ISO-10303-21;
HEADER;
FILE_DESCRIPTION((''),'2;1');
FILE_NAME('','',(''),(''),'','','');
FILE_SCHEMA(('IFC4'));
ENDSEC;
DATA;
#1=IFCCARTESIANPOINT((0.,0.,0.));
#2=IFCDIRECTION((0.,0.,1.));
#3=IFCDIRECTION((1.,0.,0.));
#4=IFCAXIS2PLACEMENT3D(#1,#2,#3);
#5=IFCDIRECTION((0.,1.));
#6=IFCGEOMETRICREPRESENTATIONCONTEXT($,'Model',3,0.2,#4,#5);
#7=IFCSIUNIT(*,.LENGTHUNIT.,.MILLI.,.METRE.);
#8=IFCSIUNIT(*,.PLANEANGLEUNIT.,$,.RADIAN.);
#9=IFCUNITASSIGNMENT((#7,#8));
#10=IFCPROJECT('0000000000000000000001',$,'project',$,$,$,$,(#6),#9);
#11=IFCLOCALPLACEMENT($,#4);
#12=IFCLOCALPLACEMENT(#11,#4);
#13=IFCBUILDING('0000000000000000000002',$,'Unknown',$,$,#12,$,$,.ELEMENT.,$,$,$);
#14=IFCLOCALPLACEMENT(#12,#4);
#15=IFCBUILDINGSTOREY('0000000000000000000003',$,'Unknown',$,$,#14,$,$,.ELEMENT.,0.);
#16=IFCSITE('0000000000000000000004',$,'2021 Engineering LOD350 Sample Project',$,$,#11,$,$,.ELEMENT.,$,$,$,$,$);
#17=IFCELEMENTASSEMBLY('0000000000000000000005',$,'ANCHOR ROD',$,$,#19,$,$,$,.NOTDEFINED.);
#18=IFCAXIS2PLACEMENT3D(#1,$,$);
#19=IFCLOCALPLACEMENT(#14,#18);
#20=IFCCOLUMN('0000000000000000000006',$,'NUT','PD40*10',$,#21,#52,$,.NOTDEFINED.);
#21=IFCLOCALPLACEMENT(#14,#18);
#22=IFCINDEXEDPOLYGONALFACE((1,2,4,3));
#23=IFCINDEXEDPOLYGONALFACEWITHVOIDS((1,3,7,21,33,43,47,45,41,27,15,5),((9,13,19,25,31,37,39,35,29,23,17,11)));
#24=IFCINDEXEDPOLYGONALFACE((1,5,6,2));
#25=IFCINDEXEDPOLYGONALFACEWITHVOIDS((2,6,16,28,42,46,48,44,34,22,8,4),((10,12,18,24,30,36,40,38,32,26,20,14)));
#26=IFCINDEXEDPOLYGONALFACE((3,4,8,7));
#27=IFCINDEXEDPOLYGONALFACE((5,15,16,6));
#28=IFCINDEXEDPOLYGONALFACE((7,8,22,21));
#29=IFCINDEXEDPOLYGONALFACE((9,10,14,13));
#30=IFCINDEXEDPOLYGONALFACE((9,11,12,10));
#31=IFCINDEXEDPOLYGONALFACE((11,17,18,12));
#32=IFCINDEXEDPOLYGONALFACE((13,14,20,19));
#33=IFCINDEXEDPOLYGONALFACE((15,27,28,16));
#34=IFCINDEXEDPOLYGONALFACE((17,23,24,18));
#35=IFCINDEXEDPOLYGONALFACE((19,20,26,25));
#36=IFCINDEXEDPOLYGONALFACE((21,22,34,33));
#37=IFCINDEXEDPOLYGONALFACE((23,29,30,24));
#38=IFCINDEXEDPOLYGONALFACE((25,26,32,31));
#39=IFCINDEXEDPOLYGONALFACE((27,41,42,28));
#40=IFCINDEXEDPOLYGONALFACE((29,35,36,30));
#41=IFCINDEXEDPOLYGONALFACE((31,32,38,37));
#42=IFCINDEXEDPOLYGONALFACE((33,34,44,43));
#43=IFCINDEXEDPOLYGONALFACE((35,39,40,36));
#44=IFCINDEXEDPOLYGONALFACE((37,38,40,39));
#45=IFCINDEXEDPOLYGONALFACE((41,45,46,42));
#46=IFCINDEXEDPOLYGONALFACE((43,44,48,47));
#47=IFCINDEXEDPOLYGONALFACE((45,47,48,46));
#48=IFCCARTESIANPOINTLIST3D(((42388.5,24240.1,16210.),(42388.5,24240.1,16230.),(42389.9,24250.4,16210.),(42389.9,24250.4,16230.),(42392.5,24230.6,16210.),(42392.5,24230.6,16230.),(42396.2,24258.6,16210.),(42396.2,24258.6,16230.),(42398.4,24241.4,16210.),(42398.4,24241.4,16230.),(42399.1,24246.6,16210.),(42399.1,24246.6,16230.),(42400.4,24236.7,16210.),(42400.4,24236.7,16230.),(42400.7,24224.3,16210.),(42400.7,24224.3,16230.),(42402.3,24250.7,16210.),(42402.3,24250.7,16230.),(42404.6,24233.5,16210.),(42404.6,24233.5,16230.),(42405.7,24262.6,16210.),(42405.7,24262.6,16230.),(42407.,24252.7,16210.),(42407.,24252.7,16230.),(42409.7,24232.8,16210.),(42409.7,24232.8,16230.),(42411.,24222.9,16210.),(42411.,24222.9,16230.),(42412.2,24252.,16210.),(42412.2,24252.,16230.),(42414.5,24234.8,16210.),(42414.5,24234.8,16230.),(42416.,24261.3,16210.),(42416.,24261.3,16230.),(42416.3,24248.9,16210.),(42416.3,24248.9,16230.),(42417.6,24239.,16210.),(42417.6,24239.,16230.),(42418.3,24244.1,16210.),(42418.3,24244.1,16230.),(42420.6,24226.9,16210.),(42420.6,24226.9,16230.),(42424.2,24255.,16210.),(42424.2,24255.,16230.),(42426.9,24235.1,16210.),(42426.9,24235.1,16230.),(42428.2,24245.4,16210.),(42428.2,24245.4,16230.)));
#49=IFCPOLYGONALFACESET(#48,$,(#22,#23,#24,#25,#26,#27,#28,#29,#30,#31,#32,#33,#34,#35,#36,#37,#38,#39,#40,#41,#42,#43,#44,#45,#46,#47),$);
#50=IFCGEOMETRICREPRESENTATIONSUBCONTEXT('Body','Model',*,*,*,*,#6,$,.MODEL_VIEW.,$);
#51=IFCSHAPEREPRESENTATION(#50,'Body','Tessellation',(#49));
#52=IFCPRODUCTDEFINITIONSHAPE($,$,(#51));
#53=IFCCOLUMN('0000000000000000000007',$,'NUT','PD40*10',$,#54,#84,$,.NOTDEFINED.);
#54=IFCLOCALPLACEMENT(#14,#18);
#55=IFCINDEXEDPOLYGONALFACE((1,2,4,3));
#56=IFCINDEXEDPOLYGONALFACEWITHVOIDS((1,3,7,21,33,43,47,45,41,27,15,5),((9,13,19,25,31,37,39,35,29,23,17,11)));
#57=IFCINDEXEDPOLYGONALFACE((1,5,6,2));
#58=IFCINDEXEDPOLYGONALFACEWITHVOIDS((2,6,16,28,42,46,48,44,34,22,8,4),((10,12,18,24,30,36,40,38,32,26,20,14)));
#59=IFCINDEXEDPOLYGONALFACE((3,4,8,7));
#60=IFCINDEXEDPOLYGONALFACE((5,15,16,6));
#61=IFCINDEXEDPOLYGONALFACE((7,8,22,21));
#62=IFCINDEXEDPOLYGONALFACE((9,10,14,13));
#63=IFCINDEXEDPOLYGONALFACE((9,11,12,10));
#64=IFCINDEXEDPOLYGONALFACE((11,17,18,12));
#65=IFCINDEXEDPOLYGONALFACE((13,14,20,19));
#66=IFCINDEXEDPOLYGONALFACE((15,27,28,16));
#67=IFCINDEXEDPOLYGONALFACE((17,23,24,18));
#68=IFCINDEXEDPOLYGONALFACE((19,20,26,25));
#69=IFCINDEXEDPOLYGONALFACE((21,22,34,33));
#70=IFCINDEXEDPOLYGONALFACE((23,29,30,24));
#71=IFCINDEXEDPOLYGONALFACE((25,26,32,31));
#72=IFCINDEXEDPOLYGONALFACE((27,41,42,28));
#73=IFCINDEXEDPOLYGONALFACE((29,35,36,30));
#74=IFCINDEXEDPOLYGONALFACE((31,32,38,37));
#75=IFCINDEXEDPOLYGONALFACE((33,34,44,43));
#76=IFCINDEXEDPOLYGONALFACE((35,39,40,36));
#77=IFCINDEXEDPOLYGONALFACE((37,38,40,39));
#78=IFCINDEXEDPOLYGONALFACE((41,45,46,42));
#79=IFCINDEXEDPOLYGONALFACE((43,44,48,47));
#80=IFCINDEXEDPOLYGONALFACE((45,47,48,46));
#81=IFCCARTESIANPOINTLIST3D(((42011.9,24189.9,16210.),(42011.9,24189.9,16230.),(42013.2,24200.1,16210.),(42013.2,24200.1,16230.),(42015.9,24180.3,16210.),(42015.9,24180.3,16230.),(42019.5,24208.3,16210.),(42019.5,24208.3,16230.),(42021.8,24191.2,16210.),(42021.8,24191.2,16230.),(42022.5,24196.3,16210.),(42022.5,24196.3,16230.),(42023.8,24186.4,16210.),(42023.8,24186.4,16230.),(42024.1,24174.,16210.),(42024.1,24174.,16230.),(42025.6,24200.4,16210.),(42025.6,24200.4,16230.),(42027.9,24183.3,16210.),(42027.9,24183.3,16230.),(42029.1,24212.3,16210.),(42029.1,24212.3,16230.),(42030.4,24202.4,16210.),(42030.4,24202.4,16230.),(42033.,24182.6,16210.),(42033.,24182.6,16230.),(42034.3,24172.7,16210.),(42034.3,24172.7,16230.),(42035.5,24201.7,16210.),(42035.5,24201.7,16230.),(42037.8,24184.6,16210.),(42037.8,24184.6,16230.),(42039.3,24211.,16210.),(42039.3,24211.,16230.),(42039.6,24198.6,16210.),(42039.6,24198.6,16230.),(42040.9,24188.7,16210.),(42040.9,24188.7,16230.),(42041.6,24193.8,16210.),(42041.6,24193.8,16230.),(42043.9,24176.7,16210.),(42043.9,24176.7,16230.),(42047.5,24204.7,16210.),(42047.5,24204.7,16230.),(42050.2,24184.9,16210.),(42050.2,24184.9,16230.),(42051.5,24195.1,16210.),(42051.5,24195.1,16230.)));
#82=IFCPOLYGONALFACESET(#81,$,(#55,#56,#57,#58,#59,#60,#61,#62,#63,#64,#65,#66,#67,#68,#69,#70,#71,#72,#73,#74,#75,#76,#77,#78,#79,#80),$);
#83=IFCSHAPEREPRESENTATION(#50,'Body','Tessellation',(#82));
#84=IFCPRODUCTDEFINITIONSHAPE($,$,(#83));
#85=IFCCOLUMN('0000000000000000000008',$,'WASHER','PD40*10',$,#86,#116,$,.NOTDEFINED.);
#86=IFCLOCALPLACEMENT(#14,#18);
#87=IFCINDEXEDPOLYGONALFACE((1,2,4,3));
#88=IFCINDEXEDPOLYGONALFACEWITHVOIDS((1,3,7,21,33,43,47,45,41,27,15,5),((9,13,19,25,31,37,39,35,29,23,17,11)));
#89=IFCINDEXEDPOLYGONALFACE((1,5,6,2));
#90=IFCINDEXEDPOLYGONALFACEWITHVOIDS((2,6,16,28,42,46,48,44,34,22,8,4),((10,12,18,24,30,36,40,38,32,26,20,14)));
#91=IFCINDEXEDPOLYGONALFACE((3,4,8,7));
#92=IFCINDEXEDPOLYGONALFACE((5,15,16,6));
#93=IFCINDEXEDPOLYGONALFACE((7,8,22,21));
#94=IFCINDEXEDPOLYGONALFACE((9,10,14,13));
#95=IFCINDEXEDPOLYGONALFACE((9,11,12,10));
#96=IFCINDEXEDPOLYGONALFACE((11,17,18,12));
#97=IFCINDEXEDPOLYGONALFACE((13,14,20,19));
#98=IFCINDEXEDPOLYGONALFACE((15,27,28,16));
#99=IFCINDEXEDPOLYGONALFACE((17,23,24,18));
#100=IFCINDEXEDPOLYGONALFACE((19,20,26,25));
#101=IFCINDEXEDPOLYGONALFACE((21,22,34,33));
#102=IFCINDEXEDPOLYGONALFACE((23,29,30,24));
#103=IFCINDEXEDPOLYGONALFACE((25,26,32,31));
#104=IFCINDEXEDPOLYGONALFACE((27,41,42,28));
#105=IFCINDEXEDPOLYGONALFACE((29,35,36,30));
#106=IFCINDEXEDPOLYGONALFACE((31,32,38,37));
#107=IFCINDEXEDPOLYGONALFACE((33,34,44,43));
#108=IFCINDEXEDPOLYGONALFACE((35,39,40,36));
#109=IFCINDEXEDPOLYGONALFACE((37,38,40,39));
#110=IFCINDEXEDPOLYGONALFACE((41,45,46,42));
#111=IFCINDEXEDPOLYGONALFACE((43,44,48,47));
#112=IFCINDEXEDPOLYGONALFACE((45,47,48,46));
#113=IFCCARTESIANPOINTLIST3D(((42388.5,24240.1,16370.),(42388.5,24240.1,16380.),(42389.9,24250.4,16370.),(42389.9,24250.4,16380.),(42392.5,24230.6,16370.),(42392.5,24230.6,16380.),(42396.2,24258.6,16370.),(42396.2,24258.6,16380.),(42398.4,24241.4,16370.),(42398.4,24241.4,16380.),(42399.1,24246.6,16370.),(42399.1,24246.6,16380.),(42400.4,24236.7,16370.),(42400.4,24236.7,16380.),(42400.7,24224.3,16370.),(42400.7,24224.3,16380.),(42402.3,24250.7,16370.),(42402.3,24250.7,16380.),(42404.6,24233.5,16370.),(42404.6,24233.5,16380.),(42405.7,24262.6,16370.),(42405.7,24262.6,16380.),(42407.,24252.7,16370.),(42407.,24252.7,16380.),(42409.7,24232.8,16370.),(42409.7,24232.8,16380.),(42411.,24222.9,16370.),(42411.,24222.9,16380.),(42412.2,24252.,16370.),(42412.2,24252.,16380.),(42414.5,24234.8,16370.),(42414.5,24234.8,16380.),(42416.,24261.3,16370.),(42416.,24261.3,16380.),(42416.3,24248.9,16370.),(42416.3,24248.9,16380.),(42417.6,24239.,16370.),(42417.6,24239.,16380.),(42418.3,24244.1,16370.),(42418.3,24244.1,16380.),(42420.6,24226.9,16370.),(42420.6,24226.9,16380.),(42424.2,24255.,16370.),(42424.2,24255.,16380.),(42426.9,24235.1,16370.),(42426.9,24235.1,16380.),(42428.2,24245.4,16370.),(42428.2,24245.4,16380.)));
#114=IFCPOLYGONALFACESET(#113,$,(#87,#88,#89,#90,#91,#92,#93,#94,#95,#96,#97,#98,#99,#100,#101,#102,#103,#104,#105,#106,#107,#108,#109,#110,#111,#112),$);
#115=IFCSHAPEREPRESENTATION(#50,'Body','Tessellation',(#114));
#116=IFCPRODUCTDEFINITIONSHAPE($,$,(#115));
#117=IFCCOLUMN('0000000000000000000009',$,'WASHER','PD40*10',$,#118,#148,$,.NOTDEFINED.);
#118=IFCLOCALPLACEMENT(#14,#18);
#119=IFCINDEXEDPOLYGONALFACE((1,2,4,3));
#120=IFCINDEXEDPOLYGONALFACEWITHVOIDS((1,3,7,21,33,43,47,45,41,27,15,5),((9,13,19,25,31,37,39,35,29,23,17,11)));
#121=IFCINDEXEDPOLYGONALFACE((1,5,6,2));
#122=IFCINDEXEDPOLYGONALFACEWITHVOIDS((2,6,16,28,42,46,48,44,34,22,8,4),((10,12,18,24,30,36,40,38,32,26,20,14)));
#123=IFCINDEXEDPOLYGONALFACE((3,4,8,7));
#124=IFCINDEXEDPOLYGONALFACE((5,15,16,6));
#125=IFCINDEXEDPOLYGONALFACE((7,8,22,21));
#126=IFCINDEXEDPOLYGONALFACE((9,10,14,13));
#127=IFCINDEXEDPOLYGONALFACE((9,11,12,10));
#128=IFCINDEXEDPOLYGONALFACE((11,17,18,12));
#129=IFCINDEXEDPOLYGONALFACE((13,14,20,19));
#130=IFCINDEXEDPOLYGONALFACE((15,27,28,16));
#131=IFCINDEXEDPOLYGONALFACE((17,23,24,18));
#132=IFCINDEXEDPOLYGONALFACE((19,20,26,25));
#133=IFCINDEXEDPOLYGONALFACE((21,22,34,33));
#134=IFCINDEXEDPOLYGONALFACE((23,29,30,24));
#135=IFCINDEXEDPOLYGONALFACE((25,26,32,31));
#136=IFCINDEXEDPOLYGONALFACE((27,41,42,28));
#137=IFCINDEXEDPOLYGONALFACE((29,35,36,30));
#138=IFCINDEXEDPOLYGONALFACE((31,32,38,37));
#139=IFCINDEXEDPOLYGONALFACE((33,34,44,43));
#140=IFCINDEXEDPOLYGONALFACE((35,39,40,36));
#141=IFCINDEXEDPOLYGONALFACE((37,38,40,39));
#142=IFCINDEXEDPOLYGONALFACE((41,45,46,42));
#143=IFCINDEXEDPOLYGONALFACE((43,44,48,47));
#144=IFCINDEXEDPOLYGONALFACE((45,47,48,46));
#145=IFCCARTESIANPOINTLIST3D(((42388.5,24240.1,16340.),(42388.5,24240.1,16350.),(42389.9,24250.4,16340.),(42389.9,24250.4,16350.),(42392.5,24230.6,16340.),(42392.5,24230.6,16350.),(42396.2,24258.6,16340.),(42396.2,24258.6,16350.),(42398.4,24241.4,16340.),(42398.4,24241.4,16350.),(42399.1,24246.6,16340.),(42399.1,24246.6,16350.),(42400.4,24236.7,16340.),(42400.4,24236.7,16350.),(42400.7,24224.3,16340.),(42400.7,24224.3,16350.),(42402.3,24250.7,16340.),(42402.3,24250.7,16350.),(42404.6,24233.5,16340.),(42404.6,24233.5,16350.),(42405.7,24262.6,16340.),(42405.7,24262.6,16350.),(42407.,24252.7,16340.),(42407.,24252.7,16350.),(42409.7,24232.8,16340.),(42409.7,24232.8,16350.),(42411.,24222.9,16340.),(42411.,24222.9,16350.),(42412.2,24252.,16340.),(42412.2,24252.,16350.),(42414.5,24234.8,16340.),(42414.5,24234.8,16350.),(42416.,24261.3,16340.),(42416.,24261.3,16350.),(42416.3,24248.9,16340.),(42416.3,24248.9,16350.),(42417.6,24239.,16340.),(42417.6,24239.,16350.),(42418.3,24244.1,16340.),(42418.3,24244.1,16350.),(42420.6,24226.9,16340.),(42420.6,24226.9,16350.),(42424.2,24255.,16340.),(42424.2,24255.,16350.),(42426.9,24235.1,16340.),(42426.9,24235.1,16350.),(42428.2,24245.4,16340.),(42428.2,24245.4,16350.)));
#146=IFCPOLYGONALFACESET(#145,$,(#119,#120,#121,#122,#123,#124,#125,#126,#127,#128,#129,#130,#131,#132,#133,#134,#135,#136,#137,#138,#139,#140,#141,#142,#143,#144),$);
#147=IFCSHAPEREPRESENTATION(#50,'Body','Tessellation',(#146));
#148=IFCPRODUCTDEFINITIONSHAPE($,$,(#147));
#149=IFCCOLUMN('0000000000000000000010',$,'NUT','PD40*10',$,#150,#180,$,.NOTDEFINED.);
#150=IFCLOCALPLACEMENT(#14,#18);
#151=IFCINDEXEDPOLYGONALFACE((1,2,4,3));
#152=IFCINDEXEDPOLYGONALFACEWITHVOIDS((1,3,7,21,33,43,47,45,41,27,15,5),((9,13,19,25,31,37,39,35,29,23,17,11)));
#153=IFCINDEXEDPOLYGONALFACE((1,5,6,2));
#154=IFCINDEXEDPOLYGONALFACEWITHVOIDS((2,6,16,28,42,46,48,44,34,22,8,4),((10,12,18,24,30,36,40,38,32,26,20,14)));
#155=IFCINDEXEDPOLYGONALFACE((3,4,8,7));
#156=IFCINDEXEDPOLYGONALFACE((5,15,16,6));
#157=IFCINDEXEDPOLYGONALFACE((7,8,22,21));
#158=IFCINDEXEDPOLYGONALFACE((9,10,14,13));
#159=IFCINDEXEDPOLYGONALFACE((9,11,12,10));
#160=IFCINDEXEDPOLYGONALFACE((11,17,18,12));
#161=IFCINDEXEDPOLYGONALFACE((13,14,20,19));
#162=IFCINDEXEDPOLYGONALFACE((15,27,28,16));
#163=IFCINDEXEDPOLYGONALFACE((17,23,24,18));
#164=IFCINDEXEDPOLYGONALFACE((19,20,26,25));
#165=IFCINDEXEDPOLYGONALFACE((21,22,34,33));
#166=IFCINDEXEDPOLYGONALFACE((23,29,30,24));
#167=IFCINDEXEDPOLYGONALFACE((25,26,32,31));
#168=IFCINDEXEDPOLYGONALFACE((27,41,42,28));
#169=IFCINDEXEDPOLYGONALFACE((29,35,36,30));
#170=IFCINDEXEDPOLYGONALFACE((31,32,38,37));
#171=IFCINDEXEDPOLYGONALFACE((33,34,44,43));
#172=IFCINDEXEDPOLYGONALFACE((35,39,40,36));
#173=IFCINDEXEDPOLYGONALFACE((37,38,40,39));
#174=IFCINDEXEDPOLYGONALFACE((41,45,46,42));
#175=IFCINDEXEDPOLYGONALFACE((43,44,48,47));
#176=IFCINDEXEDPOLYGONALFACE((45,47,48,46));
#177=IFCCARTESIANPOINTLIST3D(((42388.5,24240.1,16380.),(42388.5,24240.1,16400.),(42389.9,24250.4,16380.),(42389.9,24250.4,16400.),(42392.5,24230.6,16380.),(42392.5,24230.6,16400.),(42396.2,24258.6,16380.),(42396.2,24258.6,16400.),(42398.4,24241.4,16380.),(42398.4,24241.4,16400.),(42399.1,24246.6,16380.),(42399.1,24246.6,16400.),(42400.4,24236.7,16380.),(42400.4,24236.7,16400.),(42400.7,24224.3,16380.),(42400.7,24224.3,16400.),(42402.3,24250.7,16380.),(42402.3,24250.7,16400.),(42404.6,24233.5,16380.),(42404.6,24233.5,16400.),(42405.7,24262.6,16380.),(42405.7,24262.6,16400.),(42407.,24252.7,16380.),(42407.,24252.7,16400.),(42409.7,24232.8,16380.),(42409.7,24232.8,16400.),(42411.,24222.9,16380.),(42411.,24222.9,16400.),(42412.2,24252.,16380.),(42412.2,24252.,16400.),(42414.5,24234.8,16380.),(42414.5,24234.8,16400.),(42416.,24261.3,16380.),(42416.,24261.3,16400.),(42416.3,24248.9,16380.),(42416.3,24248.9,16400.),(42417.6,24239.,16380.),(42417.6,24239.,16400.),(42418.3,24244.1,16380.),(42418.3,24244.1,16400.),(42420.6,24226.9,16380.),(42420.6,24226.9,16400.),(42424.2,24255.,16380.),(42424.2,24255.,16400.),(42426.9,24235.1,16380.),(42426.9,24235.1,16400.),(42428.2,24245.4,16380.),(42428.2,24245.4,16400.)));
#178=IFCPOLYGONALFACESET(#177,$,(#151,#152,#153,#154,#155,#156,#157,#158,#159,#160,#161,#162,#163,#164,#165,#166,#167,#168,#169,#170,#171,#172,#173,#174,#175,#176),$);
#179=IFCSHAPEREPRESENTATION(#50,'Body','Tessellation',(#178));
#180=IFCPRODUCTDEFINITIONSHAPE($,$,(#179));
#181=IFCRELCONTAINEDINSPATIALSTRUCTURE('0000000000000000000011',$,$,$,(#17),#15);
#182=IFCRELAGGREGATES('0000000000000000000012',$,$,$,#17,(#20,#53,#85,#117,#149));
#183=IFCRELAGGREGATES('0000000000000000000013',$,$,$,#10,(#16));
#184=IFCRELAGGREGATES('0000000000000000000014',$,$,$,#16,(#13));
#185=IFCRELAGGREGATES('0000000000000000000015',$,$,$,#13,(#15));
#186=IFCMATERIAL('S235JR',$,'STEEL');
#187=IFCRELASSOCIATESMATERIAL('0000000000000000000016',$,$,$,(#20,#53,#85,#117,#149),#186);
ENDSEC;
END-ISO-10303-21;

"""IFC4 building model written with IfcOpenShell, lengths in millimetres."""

from ifc_helpers import new_model, si_unit, direction, frame, origin_with_axes, place, context, subcontext, project, spatial, line, indexed_curve, outline, extrude, material, element, aggregate, save


model = new_model("IFC4")

# Units and contexts
model_context = context("Model", 3, precision=0.2, world=origin_with_axes(), true_north=direction((0.0, 1.0)))
body_context = subcontext(model_context, "Body", "Model", "MODEL_VIEW")
ifc_project = project(units=[si_unit("LENGTHUNIT", "METRE", prefix="MILLI"), si_unit("PLANEANGLEUNIT", "RADIAN")], contexts=[model_context])

# Site, building, storey
site_placement = place(None, origin_with_axes())
site = spatial("IfcSite", under=ifc_project, at=site_placement, Name="2021 Engineering LOD350 Sample Project", CompositionType="ELEMENT")
building_placement = place(site_placement, origin_with_axes())
building = spatial("IfcBuilding", under=site, at=building_placement, Name="Unknown", CompositionType="ELEMENT")
storey_placement = place(building_placement, origin_with_axes())
storey = spatial("IfcBuildingStorey", under=building, at=storey_placement, Name="Unknown", CompositionType="ELEMENT", Elevation=0.0)

# Element assembly, columns
assembly_1_placement = place(storey_placement, frame((42408.4, 24242.8, 16410.0), z_axis=(0.991216, 0.132256, 0.0), x_axis=(0.0, 0.0, -1.0)))
assembly_1 = element("IfcElementAssembly", 1, at=assembly_1_placement, inside=storey, Name="ANCHOR ROD", PredefinedType="NOTDEFINED")
ifc_material_1 = material(Name="S235JR", Category="STEEL")
column_1_placement = place(assembly_1_placement, frame((180.0, 0.0, 0.0), z_axis=(0.0, 0.0, 1.0), x_axis=(1.0, 0.0, 0.0)))
column_1 = element("IfcColumn", 2, at=column_1_placement, material=ifc_material_1, Name="NUT", Description="PD40*10", PredefinedType="NOTDEFINED", context=body_context, shape_type="SolidModel", body=[
    extrude(outline(indexed_curve([(20.0, 0.0), (17.3, 10.0), (10.0, 17.3), (0.0, 20.0), (-10.0, 17.3), (-17.3, 10.0), (-20.0, 0.0), (-17.3, -10.0), (-10.0, -17.3), (0.0, -20.0), (10.0, -17.3), (17.3, -10.0)], segments=[line(1, 2, 3, 4, 5, 6, 7, 8, 9, 10, 11, 12, 1)]), holes=[indexed_curve([(10.0, 0.0), (8.7, -5.0), (5.0, -8.7), (0.0, -10.0), (-5.0, -8.7), (-8.7, -5.0), (-10.0, 0.0), (-8.7, 5.0), (-5.0, 8.7), (0.0, 10.0), (5.0, 8.7), (8.7, 5.0)], segments=[line(1, 2, 3, 4, 5, 6, 7, 8, 9, 10, 11, 12, 1)])]), frame((0.0, 0.0, 0.0), z_axis=(-1.0, 0.0, 0.0), x_axis=(0.0, 0.0, 1.0)), (0.0, 0.0, -1.0), 20.0),
])
column_2_placement = place(assembly_1_placement, frame((180.0, 0.0, -380.0), z_axis=(0.0, 0.0, -1.0), x_axis=(1.0, 0.0, 0.0)))
column_2 = element("IfcColumn", 3, at=column_2_placement, material=ifc_material_1, Name="NUT", Description="PD40*10", PredefinedType="NOTDEFINED", context=body_context, shape_type="SolidModel", body=[
    extrude(outline(indexed_curve([(20.0, 0.0), (17.3, 10.0), (10.0, 17.3), (0.0, 20.0), (-10.0, 17.3), (-17.3, 10.0), (-20.0, 0.0), (-17.3, -10.0), (-10.0, -17.3), (0.0, -20.0), (10.0, -17.3), (17.3, -10.0)], segments=[line(1, 2, 3, 4, 5, 6, 7, 8, 9, 10, 11, 12, 1)]), holes=[indexed_curve([(10.0, 0.0), (8.7, -5.0), (5.0, -8.7), (0.0, -10.0), (-5.0, -8.7), (-8.7, -5.0), (-10.0, 0.0), (-8.7, 5.0), (-5.0, 8.7), (0.0, 10.0), (5.0, 8.7), (8.7, 5.0)], segments=[line(1, 2, 3, 4, 5, 6, 7, 8, 9, 10, 11, 12, 1)])]), frame((0.0, 0.0, 0.0), z_axis=(-1.0, 0.0, 0.0), x_axis=(0.0, 0.0, 1.0)), (0.0, 0.0, -1.0), 20.0),
])
column_3_placement = place(assembly_1_placement, frame((30.0, 0.0, 0.0), z_axis=(0.0, 0.0, 1.0), x_axis=(1.0, 0.0, 0.0)))
column_3 = element("IfcColumn", 4, at=column_3_placement, material=ifc_material_1, Name="WASHER", Description="PD40*10", PredefinedType="NOTDEFINED", context=body_context, shape_type="SolidModel", body=[
    extrude(outline(indexed_curve([(20.0, 0.0), (17.3, 10.0), (10.0, 17.3), (0.0, 20.0), (-10.0, 17.3), (-17.3, 10.0), (-20.0, 0.0), (-17.3, -10.0), (-10.0, -17.3), (0.0, -20.0), (10.0, -17.3), (17.3, -10.0)], segments=[line(1, 2, 3, 4, 5, 6, 7, 8, 9, 10, 11, 12, 1)]), holes=[indexed_curve([(10.0, 0.0), (8.7, -5.0), (5.0, -8.7), (0.0, -10.0), (-5.0, -8.7), (-8.7, -5.0), (-10.0, 0.0), (-8.7, 5.0), (-5.0, 8.7), (0.0, 10.0), (5.0, 8.7), (8.7, 5.0)], segments=[line(1, 2, 3, 4, 5, 6, 7, 8, 9, 10, 11, 12, 1)])]), frame((0.0, 0.0, 0.0), z_axis=(-1.0, 0.0, 0.0), x_axis=(0.0, 0.0, 1.0)), (0.0, 0.0, -1.0), 10.0),
])
column_4_placement = place(assembly_1_placement, frame((60.0, 0.0, 0.0), z_axis=(0.0, 0.0, 1.0), x_axis=(1.0, 0.0, 0.0)))
column_4 = element("IfcColumn", 5, at=column_4_placement, material=ifc_material_1, Name="WASHER", Description="PD40*10", PredefinedType="NOTDEFINED", context=body_context, shape_type="SolidModel", body=[
    extrude(outline(indexed_curve([(20.0, 0.0), (17.3, 10.0), (10.0, 17.3), (0.0, 20.0), (-10.0, 17.3), (-17.3, 10.0), (-20.0, 0.0), (-17.3, -10.0), (-10.0, -17.3), (0.0, -20.0), (10.0, -17.3), (17.3, -10.0)], segments=[line(1, 2, 3, 4, 5, 6, 7, 8, 9, 10, 11, 12, 1)]), holes=[indexed_curve([(10.0, 0.0), (8.7, -5.0), (5.0, -8.7), (0.0, -10.0), (-5.0, -8.7), (-8.7, -5.0), (-10.0, 0.0), (-8.7, 5.0), (-5.0, 8.7), (0.0, 10.0), (5.0, 8.7), (8.7, 5.0)], segments=[line(1, 2, 3, 4, 5, 6, 7, 8, 9, 10, 11, 12, 1)])]), frame((0.0, 0.0, 0.0), z_axis=(-1.0, 0.0, 0.0), x_axis=(0.0, 0.0, 1.0)), (0.0, 0.0, -1.0), 10.0),
])
column_5_placement = place(assembly_1_placement, frame((10.0, 0.0, 0.0), z_axis=(0.0, 0.0, 1.0), x_axis=(1.0, 0.0, 0.0)))
column_5 = element("IfcColumn", 6, at=column_5_placement, material=ifc_material_1, Name="NUT", Description="PD40*10", PredefinedType="NOTDEFINED", context=body_context, shape_type="SolidModel", body=[
    extrude(outline(indexed_curve([(20.0, 0.0), (17.3, 10.0), (10.0, 17.3), (0.0, 20.0), (-10.0, 17.3), (-17.3, 10.0), (-20.0, 0.0), (-17.3, -10.0), (-10.0, -17.3), (0.0, -20.0), (10.0, -17.3), (17.3, -10.0)], segments=[line(1, 2, 3, 4, 5, 6, 7, 8, 9, 10, 11, 12, 1)]), holes=[indexed_curve([(10.0, 0.0), (8.7, -5.0), (5.0, -8.7), (0.0, -10.0), (-5.0, -8.7), (-8.7, -5.0), (-10.0, 0.0), (-8.7, 5.0), (-5.0, 8.7), (0.0, 10.0), (5.0, 8.7), (8.7, 5.0)], segments=[line(1, 2, 3, 4, 5, 6, 7, 8, 9, 10, 11, 12, 1)])]), frame((0.0, 0.0, 0.0), z_axis=(-1.0, 0.0, 0.0), x_axis=(0.0, 0.0, 1.0)), (0.0, 0.0, -1.0), 20.0),
])

aggregate(assembly_1, [column_1, column_2, column_3, column_4, column_5])

save(model, "model.ifc")
